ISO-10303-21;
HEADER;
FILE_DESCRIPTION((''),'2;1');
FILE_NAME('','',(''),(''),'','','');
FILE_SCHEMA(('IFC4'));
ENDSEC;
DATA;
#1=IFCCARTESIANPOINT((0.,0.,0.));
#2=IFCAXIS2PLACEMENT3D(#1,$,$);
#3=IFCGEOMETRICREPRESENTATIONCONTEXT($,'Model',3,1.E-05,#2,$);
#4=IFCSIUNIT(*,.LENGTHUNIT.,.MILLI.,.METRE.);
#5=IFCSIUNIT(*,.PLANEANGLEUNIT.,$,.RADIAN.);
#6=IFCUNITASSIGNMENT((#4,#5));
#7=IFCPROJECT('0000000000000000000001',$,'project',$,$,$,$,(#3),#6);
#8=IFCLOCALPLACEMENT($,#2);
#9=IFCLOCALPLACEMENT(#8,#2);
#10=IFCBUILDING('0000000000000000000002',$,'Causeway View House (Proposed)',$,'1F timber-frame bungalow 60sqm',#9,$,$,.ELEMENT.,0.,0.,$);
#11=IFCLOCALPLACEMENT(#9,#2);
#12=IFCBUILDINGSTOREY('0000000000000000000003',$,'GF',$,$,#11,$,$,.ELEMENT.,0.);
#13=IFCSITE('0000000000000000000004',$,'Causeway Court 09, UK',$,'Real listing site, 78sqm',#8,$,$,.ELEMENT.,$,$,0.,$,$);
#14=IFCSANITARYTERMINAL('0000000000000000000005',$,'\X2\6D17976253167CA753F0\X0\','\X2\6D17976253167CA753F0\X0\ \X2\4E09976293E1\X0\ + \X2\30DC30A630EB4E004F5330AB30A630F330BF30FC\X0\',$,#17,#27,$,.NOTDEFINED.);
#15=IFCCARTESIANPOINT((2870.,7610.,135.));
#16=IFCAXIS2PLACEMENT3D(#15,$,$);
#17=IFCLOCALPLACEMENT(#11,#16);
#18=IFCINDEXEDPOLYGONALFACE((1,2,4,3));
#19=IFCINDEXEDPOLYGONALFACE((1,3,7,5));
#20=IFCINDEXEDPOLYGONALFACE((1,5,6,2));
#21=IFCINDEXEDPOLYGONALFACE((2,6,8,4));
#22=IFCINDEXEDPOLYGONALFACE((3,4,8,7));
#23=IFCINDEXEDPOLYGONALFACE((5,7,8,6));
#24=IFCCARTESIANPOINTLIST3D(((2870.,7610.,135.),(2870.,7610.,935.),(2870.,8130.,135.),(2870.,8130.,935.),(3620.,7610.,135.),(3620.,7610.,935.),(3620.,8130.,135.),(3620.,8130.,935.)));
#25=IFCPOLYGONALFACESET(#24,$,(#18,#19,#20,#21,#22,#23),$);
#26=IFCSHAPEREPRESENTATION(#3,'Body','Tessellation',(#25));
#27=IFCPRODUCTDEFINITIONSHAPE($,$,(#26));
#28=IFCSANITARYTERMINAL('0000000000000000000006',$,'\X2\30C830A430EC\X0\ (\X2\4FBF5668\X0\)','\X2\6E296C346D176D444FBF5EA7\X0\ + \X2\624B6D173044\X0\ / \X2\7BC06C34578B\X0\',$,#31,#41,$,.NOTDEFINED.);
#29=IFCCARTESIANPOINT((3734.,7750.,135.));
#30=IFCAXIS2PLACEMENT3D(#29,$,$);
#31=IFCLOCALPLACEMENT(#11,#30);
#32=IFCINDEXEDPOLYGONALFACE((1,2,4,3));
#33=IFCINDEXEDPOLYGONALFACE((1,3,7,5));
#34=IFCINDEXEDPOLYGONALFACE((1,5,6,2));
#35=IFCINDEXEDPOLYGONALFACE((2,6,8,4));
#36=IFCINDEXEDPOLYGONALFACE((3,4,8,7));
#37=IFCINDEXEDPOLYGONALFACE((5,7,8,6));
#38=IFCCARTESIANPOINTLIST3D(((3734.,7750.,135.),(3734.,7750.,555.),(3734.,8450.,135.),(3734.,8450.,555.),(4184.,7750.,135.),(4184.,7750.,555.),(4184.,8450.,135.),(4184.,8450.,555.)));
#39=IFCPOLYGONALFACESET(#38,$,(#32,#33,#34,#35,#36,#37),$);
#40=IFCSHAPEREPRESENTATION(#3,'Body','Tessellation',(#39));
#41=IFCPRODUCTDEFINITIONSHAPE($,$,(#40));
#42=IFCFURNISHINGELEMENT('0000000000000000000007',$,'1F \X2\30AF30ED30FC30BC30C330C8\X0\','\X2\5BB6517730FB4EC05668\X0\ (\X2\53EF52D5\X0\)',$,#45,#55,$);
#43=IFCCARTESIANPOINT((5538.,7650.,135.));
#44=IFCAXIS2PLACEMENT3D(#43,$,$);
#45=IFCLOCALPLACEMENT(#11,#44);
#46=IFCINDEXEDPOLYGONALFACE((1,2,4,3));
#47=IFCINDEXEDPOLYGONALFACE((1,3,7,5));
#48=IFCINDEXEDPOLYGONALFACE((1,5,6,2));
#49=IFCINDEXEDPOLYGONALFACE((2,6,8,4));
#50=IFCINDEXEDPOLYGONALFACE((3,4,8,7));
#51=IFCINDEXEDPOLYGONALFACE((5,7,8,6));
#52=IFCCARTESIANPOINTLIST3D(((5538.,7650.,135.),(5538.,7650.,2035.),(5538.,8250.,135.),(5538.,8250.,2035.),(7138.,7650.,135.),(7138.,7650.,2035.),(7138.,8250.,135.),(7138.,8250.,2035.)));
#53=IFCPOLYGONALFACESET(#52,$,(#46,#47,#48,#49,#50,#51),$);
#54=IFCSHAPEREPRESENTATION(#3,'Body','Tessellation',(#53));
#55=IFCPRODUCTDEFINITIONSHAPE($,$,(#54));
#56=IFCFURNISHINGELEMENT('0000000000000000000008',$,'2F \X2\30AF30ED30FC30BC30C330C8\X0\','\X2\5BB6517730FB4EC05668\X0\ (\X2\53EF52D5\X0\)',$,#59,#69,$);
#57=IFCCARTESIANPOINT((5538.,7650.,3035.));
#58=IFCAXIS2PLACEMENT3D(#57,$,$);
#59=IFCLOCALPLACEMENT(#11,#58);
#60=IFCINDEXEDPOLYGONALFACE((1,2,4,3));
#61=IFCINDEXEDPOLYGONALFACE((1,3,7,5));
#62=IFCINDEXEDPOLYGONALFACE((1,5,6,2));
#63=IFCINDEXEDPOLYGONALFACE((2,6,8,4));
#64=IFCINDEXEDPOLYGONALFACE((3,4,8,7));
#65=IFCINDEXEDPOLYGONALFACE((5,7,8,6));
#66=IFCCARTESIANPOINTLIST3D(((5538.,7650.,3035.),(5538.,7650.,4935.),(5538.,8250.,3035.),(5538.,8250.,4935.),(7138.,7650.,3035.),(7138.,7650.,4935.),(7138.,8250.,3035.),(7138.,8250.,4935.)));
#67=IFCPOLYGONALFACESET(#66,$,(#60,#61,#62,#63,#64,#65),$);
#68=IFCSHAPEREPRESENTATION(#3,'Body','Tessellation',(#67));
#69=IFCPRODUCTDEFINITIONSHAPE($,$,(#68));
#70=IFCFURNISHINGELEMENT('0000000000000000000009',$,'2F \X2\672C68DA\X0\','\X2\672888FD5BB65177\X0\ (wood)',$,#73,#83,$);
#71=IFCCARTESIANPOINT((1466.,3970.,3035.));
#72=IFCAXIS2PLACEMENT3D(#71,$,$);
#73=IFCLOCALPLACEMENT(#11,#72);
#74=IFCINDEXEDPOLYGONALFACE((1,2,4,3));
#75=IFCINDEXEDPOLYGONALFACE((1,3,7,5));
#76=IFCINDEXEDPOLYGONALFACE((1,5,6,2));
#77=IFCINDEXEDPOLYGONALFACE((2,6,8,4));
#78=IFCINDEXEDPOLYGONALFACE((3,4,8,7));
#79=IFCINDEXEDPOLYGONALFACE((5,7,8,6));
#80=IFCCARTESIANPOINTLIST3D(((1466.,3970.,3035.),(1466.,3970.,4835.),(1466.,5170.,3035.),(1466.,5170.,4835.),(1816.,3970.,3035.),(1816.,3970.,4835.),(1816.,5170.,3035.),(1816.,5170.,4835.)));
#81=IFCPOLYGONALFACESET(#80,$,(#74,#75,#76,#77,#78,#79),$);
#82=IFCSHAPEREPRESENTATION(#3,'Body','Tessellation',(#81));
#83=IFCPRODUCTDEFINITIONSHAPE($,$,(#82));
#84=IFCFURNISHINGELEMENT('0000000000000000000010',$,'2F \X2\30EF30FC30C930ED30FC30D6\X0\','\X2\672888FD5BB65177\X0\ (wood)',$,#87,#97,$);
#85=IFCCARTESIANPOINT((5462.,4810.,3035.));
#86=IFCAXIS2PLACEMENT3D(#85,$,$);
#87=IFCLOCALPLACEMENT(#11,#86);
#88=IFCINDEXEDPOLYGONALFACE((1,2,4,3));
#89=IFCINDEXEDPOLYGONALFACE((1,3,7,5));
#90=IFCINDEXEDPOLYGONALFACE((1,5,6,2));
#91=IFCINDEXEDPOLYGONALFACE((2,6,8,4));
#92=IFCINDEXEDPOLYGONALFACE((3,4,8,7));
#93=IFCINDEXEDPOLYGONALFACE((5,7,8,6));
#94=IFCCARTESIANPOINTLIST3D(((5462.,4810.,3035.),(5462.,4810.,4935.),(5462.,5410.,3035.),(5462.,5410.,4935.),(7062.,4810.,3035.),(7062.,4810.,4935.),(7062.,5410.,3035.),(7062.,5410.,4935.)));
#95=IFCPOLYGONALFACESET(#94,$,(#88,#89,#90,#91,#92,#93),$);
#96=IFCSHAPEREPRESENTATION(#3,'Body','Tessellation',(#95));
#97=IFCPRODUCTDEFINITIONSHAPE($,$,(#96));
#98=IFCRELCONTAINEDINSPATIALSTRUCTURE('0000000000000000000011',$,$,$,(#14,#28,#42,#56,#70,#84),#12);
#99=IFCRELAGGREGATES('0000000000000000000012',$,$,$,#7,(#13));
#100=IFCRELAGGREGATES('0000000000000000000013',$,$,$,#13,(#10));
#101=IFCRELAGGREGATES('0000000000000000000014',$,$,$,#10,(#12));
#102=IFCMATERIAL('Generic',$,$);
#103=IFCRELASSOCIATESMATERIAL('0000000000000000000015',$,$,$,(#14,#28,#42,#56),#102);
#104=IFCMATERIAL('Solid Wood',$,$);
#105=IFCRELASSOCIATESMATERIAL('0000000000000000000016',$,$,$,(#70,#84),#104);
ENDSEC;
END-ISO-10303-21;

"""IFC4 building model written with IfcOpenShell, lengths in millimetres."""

from ifc_helpers import new_model, si_unit, frame, frame_2d, origin, place, context, project, spatial, rectangle, extrude, material, element, save


model = new_model("IFC4")

# Units and contexts
model_context = context("Model", 3, precision=1e-05, world=origin())
ifc_project = project(units=[si_unit("LENGTHUNIT", "METRE", prefix="MILLI"), si_unit("PLANEANGLEUNIT", "RADIAN")], contexts=[model_context])

# Site, building, storey
site_placement = place(None, origin())
site = spatial("IfcSite", under=ifc_project, at=site_placement, Name="Causeway Court 09, UK", ObjectType="Real listing site, 78sqm", CompositionType="ELEMENT", RefElevation=0.0)
building_placement = place(site_placement, origin())
building = spatial("IfcBuilding", under=site, at=building_placement, Name="Causeway View House (Proposed)", ObjectType="1F timber-frame bungalow 60sqm", CompositionType="ELEMENT", ElevationOfRefHeight=0.0, ElevationOfTerrain=0.0)
storey_placement = place(building_placement, origin())
storey = spatial("IfcBuildingStorey", under=building, at=storey_placement, Name="GF", CompositionType="ELEMENT", Elevation=0.0)

# Shared definitions
ifc_material_1 = material(Name="Solid Wood")

# Shared definitions
ifc_material_2 = material(Name="Generic")

# Sanitary terminals
sanitary_terminal_1_placement = place(storey_placement, frame((2870.0, 7610.0, 135.0)))
element("IfcSanitaryTerminal", 1, at=sanitary_terminal_1_placement, inside=storey, material=ifc_material_2, Name="洗面化粧台", Description="洗面化粧台 三面鏡 + ボウル一体カウンター", PredefinedType="NOTDEFINED", context=model_context, shape_type="SweptSolid", body=[
    extrude(rectangle(XDim=750.0, YDim=520.0, at=frame_2d((375.0, 260.0))), frame((2870.0, 7610.0, 135.0)), (0.0, 0.0, 1.0), 800.0),
])
sanitary_terminal_2_placement = place(storey_placement, frame((3734.0, 7750.0, 135.0)))
element("IfcSanitaryTerminal", 2, at=sanitary_terminal_2_placement, inside=storey, material=ifc_material_2, Name="トイレ (便器)", Description="温水洗浄便座 + 手洗い / 節水型", PredefinedType="NOTDEFINED", context=model_context, shape_type="SweptSolid", body=[
    extrude(rectangle(XDim=450.0, YDim=700.0, at=frame_2d((225.0, 350.0))), frame((3734.0, 7750.0, 135.0)), (0.0, 0.0, 1.0), 420.0),
])

# Furnishing elements
furnishing_1_placement = place(storey_placement, frame((5538.0, 7650.0, 135.0)))
element("IfcFurnishingElement", 3, at=furnishing_1_placement, inside=storey, material=ifc_material_2, Name="1F クローゼット", Description="家具・什器 (可動)", context=model_context, shape_type="SweptSolid", body=[
    extrude(rectangle(XDim=1600.0, YDim=600.0, at=frame_2d((800.0, 300.0))), frame((5538.0, 7650.0, 135.0)), (0.0, 0.0, 1.0), 1900.0),
])
furnishing_2_placement = place(storey_placement, frame((5538.0, 7650.0, 3035.0)))
element("IfcFurnishingElement", 4, at=furnishing_2_placement, inside=storey, material=ifc_material_2, Name="2F クローゼット", Description="家具・什器 (可動)", context=model_context, shape_type="SweptSolid", body=[
    extrude(rectangle(XDim=1600.0, YDim=600.0, at=frame_2d((800.0, 300.0))), frame((5538.0, 7650.0, 3035.0)), (0.0, 0.0, 1.0), 1900.0),
])
furnishing_3_placement = place(storey_placement, frame((1466.0, 3970.0, 3035.0)))
element("IfcFurnishingElement", 5, at=furnishing_3_placement, inside=storey, material=ifc_material_1, Name="2F 本棚", Description="木製家具 (wood)", context=model_context, shape_type="SweptSolid", body=[
    extrude(rectangle(XDim=350.0, YDim=1200.0, at=frame_2d((175.0, 600.0))), frame((1466.0, 3970.0, 3035.0)), (0.0, 0.0, 1.0), 1800.0),
])
furnishing_4_placement = place(storey_placement, frame((5462.0, 4810.0, 3035.0)))
element("IfcFurnishingElement", 6, at=furnishing_4_placement, inside=storey, material=ifc_material_1, Name="2F ワードローブ", Description="木製家具 (wood)", context=model_context, shape_type="SweptSolid", body=[
    extrude(rectangle(XDim=1600.0, YDim=600.0, at=frame_2d((800.0, 300.0))), frame((5462.0, 4810.0, 3035.0)), (0.0, 0.0, 1.0), 1900.0),
])

save(model, "model.ifc")
